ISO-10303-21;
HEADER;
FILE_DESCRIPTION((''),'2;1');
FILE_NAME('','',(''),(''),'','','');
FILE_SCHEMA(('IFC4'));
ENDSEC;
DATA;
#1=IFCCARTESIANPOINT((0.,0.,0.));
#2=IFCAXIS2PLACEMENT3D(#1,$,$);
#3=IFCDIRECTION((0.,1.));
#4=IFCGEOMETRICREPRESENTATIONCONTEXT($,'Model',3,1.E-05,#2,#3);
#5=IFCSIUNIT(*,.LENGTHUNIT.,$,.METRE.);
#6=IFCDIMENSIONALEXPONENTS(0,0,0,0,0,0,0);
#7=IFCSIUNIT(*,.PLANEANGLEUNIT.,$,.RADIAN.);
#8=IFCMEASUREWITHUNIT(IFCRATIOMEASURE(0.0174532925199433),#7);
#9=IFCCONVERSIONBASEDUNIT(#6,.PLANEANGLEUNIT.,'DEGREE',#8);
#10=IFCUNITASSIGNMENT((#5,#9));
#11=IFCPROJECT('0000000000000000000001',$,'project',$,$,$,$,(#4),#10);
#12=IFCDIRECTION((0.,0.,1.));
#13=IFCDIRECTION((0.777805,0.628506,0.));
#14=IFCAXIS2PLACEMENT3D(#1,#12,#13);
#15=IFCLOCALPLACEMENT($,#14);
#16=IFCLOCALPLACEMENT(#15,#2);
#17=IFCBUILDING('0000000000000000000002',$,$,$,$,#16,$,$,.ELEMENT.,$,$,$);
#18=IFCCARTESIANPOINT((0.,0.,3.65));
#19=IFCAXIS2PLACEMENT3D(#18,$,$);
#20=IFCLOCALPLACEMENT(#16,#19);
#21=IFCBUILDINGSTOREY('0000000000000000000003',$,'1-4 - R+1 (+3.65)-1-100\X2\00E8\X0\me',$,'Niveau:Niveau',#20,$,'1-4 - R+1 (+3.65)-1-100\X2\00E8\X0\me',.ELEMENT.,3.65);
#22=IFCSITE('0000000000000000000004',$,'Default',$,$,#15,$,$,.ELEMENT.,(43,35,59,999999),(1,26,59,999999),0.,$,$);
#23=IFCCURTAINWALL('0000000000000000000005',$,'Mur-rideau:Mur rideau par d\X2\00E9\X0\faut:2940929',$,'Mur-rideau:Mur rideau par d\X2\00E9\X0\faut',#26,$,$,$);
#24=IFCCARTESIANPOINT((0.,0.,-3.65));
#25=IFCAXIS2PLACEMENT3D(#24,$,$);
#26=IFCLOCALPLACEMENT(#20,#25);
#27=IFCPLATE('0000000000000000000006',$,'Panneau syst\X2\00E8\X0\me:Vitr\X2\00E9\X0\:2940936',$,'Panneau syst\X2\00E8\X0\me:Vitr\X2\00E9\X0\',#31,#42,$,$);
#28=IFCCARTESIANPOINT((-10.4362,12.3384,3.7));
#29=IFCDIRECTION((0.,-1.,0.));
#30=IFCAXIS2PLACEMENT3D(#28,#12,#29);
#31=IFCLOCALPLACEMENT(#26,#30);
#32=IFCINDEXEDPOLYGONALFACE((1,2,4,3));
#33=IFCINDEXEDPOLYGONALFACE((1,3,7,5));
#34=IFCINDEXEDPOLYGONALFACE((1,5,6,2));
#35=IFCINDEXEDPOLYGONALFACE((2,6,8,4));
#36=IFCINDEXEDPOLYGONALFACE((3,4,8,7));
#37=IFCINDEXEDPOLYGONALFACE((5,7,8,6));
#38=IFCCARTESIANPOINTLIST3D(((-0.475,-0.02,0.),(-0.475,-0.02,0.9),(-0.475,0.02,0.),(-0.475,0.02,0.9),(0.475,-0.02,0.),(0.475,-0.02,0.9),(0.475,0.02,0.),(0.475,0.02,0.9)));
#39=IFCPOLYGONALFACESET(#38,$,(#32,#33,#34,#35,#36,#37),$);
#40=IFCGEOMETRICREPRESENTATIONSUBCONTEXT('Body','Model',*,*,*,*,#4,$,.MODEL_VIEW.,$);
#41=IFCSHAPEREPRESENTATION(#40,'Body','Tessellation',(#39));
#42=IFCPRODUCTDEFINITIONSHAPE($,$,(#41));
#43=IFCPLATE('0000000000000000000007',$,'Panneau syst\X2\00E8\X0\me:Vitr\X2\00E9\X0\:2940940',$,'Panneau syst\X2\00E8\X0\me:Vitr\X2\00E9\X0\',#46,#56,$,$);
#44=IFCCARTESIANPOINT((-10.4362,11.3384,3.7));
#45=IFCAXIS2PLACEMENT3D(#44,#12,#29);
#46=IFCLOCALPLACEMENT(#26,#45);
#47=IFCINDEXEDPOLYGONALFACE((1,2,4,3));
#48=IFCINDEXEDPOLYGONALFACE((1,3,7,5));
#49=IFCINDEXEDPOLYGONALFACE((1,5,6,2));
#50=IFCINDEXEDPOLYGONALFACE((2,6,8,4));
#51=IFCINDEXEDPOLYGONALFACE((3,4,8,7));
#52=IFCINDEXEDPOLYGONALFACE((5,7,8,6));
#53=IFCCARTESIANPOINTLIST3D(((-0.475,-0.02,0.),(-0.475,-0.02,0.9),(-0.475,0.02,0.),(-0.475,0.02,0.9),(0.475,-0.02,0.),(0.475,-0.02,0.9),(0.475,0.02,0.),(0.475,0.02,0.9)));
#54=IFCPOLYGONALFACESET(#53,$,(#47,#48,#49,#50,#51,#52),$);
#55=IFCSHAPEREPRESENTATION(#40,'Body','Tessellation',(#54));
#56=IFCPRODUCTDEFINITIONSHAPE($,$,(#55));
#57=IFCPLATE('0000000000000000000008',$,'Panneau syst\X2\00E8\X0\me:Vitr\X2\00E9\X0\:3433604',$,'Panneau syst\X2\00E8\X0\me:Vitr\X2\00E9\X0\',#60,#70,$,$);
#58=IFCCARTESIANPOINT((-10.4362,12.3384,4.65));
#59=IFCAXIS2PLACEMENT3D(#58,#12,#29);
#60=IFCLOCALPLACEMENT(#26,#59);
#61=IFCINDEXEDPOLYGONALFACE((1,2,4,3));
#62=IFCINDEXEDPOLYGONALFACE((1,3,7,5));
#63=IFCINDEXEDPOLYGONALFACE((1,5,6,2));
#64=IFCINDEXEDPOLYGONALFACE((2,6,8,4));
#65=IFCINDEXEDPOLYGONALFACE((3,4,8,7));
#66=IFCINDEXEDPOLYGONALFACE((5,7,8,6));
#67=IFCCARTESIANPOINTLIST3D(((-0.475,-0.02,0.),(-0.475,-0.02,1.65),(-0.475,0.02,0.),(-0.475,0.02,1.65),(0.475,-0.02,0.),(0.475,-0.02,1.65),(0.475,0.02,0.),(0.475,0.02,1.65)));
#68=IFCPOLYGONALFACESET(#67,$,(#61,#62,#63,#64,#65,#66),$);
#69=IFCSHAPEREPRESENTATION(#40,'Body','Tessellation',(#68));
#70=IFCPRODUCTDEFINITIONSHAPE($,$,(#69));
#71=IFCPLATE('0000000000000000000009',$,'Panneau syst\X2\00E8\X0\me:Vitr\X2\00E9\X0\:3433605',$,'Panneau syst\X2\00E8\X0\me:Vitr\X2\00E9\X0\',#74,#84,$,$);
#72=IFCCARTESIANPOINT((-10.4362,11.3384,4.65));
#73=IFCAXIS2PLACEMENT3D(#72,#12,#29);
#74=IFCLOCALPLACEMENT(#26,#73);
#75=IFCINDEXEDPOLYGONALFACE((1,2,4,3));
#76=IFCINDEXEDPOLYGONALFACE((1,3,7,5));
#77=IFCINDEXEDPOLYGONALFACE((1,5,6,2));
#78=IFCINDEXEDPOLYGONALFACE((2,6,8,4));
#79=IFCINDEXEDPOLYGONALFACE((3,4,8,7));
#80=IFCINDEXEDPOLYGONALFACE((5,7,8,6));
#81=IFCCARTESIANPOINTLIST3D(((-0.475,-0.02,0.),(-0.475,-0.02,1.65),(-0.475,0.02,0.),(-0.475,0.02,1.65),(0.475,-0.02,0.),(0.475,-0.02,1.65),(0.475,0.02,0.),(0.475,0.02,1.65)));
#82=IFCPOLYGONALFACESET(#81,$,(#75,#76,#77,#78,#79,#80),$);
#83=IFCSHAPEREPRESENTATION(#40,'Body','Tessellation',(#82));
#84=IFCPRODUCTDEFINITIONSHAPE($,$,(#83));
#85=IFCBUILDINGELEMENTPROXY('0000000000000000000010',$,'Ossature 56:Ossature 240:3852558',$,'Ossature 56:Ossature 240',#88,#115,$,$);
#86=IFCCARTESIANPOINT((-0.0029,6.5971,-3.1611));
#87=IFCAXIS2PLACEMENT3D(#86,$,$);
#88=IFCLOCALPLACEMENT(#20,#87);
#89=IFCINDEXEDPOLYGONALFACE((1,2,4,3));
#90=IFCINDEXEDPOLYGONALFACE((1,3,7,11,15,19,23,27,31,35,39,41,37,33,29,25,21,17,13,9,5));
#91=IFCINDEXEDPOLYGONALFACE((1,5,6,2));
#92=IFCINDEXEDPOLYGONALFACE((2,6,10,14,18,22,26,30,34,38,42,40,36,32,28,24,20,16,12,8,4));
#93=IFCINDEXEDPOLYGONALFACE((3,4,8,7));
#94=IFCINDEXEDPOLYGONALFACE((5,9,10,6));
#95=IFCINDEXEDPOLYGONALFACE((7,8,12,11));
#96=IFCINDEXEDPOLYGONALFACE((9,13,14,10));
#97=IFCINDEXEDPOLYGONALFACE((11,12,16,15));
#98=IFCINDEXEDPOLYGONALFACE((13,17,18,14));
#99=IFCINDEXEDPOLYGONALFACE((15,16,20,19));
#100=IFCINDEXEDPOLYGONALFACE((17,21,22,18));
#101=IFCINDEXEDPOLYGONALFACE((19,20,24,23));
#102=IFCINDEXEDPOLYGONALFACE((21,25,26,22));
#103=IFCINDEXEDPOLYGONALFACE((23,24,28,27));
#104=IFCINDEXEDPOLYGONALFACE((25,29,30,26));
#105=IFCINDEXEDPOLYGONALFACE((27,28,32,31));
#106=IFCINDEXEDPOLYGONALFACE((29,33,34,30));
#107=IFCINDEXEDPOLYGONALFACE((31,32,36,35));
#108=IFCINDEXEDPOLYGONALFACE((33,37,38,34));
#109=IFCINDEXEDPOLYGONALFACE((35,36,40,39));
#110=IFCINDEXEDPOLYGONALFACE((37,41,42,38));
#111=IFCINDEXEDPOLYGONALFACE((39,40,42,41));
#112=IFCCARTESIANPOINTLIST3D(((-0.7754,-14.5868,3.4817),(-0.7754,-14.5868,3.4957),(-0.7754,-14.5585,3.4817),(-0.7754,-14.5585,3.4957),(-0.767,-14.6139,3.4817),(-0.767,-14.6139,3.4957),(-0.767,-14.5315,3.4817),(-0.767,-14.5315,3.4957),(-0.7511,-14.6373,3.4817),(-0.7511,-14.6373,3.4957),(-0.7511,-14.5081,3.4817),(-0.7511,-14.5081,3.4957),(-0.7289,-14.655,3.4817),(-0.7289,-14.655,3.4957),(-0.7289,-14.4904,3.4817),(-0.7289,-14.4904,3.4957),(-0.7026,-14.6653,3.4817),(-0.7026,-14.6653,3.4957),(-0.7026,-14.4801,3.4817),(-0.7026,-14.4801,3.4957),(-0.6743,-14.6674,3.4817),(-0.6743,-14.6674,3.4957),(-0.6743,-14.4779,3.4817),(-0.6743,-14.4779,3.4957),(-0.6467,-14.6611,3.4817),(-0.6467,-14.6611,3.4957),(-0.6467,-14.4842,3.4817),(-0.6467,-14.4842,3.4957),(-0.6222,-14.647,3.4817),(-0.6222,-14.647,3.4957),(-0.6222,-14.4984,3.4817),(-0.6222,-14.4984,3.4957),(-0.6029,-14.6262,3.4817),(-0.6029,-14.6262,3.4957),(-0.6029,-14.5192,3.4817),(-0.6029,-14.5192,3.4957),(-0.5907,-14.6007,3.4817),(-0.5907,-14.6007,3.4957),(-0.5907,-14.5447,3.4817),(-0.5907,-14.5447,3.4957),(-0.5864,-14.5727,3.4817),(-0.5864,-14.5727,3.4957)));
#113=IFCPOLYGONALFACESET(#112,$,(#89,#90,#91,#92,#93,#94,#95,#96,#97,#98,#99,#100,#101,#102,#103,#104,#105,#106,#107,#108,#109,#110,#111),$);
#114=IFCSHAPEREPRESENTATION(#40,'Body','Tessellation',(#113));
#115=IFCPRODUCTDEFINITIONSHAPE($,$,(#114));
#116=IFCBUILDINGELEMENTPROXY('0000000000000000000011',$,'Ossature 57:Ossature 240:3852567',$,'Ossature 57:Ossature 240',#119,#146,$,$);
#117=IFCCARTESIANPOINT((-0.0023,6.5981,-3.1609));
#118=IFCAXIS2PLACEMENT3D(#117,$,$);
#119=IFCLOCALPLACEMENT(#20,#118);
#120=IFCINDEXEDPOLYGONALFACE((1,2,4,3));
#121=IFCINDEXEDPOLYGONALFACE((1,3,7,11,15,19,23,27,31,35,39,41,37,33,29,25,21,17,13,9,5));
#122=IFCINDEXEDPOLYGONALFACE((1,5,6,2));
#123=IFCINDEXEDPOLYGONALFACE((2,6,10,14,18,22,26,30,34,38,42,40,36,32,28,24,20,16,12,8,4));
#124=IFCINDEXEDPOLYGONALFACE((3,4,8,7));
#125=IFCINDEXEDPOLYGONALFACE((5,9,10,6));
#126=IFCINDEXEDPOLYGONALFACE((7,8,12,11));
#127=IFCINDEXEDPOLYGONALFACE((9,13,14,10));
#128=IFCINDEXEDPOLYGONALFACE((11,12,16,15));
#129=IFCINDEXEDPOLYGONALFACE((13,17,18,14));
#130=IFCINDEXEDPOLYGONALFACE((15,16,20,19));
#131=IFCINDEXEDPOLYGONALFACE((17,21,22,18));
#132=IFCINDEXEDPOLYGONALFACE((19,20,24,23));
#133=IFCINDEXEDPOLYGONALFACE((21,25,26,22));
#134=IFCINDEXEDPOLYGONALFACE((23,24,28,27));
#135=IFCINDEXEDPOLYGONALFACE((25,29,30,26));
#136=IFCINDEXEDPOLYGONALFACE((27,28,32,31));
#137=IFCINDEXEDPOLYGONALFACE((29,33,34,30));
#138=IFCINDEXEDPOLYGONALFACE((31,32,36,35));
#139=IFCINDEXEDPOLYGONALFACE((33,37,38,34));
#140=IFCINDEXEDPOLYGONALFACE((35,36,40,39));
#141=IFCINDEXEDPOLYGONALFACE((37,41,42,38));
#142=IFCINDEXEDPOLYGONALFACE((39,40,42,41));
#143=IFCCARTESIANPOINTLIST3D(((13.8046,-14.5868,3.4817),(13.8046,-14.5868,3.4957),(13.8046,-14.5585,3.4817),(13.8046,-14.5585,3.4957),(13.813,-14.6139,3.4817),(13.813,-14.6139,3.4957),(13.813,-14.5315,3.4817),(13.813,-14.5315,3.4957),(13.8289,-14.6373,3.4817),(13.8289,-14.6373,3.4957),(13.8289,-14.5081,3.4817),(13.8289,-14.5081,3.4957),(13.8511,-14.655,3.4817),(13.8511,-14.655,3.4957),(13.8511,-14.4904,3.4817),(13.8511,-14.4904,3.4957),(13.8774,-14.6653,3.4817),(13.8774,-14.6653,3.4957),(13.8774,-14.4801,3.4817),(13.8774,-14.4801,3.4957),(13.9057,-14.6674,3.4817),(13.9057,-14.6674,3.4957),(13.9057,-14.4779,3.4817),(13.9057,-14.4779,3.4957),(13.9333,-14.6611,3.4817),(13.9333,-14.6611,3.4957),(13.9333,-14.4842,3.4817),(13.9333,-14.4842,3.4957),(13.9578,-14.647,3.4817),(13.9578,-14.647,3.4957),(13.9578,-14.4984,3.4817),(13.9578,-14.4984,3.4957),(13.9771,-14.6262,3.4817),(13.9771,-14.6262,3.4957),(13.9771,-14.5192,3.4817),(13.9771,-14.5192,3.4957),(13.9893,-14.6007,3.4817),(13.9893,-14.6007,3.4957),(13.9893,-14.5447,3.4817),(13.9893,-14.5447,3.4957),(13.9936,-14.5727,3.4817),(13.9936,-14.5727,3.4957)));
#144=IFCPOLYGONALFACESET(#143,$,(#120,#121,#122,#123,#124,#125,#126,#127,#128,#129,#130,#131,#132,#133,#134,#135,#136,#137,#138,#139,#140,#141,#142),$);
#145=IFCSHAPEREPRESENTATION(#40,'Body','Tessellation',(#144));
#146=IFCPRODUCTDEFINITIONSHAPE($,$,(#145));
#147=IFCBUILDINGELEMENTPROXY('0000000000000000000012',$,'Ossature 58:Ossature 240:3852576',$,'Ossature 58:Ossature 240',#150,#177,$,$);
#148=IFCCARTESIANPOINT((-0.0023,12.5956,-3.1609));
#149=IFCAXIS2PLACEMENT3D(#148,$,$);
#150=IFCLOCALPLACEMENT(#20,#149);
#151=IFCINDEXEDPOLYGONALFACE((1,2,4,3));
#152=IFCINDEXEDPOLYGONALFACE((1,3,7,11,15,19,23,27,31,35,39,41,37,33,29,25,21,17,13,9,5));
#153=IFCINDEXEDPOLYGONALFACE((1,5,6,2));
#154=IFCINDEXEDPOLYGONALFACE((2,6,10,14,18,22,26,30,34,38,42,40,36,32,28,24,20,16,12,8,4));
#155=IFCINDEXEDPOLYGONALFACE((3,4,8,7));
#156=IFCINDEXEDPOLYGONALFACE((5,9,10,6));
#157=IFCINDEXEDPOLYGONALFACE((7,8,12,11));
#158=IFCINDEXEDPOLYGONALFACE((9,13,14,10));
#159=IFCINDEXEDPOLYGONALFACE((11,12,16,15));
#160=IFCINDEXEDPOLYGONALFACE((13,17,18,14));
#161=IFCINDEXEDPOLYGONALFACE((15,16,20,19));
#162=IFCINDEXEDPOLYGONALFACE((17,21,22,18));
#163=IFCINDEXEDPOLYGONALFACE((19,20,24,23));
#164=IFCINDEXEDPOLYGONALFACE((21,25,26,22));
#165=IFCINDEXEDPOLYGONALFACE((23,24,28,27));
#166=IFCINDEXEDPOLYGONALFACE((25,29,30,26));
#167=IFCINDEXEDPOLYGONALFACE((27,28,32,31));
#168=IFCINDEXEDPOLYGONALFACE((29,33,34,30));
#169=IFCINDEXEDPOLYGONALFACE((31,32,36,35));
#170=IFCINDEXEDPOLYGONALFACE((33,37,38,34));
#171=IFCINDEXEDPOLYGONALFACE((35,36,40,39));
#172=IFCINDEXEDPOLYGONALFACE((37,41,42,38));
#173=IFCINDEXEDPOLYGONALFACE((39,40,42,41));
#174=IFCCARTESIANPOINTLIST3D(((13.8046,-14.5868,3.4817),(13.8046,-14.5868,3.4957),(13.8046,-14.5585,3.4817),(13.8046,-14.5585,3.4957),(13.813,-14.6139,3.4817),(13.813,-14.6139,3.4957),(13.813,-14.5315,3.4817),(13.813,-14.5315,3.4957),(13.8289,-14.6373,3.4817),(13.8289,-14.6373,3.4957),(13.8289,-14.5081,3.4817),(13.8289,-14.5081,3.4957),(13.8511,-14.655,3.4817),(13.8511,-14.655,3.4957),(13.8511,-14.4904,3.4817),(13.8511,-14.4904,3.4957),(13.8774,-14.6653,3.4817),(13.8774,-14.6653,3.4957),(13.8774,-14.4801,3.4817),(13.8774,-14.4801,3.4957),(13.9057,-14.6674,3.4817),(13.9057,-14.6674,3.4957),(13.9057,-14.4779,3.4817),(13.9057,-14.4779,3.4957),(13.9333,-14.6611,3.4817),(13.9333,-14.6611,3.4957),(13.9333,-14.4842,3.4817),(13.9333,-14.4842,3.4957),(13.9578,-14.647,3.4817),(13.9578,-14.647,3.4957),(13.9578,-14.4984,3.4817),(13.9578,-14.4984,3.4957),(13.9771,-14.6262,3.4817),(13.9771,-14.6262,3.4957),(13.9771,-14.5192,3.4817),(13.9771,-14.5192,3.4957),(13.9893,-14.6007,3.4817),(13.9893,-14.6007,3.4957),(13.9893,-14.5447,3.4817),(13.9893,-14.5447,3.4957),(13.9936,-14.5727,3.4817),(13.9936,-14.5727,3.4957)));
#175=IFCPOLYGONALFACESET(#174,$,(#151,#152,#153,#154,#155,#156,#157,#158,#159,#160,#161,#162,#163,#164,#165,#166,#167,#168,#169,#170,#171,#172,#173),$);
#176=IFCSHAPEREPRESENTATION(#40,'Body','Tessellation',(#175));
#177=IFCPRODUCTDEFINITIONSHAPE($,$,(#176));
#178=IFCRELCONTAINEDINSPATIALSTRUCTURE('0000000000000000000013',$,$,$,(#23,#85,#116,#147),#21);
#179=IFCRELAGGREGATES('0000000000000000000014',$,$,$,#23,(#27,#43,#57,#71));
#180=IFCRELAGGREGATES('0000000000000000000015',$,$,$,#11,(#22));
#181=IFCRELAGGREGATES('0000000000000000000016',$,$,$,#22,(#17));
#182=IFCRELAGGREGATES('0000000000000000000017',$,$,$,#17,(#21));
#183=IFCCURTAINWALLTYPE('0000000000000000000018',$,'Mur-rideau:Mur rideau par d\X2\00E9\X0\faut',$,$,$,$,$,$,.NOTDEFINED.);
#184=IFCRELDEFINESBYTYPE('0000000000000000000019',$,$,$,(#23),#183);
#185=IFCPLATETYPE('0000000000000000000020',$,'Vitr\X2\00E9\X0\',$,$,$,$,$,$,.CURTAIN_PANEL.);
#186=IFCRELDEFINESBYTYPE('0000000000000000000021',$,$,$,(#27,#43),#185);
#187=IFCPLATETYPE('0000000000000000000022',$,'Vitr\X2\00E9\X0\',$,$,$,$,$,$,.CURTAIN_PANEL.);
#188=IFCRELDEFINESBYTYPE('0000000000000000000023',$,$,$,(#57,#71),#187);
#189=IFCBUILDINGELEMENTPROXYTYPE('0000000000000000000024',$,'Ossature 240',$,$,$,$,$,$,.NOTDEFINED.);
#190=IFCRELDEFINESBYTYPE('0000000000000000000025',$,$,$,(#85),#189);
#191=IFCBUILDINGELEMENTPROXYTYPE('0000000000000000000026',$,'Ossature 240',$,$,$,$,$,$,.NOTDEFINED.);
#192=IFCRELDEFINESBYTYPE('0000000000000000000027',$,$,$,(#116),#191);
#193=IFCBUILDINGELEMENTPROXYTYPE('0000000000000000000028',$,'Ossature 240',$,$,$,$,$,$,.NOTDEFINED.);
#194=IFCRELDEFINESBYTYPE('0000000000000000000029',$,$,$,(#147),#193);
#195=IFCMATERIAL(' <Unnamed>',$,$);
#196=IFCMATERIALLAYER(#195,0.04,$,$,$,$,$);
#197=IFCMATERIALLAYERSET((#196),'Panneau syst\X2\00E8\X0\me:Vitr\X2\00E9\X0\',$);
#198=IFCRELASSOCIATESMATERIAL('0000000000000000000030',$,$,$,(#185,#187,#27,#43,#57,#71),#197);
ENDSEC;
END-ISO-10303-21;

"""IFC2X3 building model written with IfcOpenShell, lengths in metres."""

from ifc_helpers import new_model, entity, si_unit, converted_unit, direction, frame, frame_2d, origin, origin_2d_with_axis, place, context, subcontext, project, spatial, rectangle, circle, extrude, source, transform, mapped, material, layer, layer_set, layer_usage, type_object, type_shapes, element, aggregate, save


model = new_model("IFC2X3")

# Units and contexts
model_context = context("Model", 3, precision=1e-05, world=origin(), true_north=direction((0.0, 1.0)))
body_context = subcontext(model_context, "Body", "Model", "MODEL_VIEW")
ifc_project = project(units=[si_unit("LENGTHUNIT", "METRE"), converted_unit("PLANEANGLEUNIT", "DEGREE", entity("IfcRatioMeasure", 0.0174532925199433), si_unit("PLANEANGLEUNIT", "RADIAN"), dimensions=[0, 0, 0, 0, 0, 0, 0])], contexts=[model_context])

# Site, building, storey
site_placement = place(None, frame((0.0, 0.0, 0.0), z_axis=(0.0, 0.0, 1.0), x_axis=(0.777805, 0.628506, 0.0)))
site = spatial("IfcSite", under=ifc_project, at=site_placement, Name="Default", CompositionType="ELEMENT", RefLatitude=(43, 35, 59, 999999), RefLongitude=(1, 26, 59, 999999), RefElevation=0.0)
building_placement = place(site_placement, origin())
building = spatial("IfcBuilding", under=site, at=building_placement, CompositionType="ELEMENT")
storey_placement = place(building_placement, frame((0.0, 0.0, 3.65)))
storey = spatial("IfcBuildingStorey", under=building, at=storey_placement, Name="1-4 - R+1 (+3.65)-1-100ème", ObjectType="Niveau:Niveau", LongName="1-4 - R+1 (+3.65)-1-100ème", CompositionType="ELEMENT", Elevation=3.65)

# Curtain wall, plates
curtain_wall_type = type_object("IfcCurtainWallType", Name="Mur-rideau:Mur rideau par défaut", PredefinedType="NOTDEFINED")
curtain_wall_placement = place(storey_placement, frame((0.0, 0.0, -3.65)))
curtain_wall = element("IfcCurtainWall", 1, at=curtain_wall_placement, inside=storey, type_object=curtain_wall_type, Name="Mur-rideau:Mur rideau par défaut:2940929", ObjectType="Mur-rideau:Mur rideau par défaut")
ifc_material_1 = material(Name=" <Unnamed>")
ifc_layer = layer(ifc_material_1, 0.04)
ifc_layer_set = layer_set([ifc_layer], Name="Panneau système:Vitré")
ifc_layer_usage_1 = layer_usage(ifc_layer_set, "AXIS3", "POSITIVE", 0.0)
plate_type_1 = type_object("IfcPlateType", Name="Vitré", PredefinedType="CURTAIN_PANEL", material=ifc_layer_set)
shared_shape_1 = source(origin(), body_context, "Body", "SweptSolid", [
    extrude(rectangle(XDim=0.04, YDim=0.95, at=frame_2d((0.0, 0.0), x_axis=(1.0, 0.0))), frame((0.0, 0.0, 0.0), z_axis=(0.0, 0.0, 1.0), x_axis=(0.0, 1.0, 0.0)), (0.0, 0.0, 1.0), 0.9),
])
type_shapes(plate_type_1, [shared_shape_1])
plate_1_placement = place(curtain_wall_placement, frame((-10.4362, 12.3384, 3.7), z_axis=(0.0, 0.0, 1.0), x_axis=(0.0, -1.0, 0.0)))
plate_1 = element("IfcPlate", 2, at=plate_1_placement, type_object=plate_type_1, material=ifc_layer_usage_1, Name="Panneau système:Vitré:2940936", ObjectType="Panneau système:Vitré", context=body_context, shape_type="MappedRepresentation", body=[
    mapped(shared_shape_1, transform((0.0, 0.0, 0.0), scale=1.0)),
])
ifc_layer_usage_2 = layer_usage(ifc_layer_set, "AXIS3", "POSITIVE", 0.0)
plate_2_placement = place(curtain_wall_placement, frame((-10.4362, 11.3384, 3.7), z_axis=(0.0, 0.0, 1.0), x_axis=(0.0, -1.0, 0.0)))
plate_2 = element("IfcPlate", 3, at=plate_2_placement, type_object=plate_type_1, material=ifc_layer_usage_2, Name="Panneau système:Vitré:2940940", ObjectType="Panneau système:Vitré", context=body_context, shape_type="MappedRepresentation", body=[
    mapped(shared_shape_1, transform((0.0, 0.0, 0.0), scale=1.0)),
])
ifc_layer_usage_3 = layer_usage(ifc_layer_set, "AXIS3", "POSITIVE", 0.0)
plate_type_2 = type_object("IfcPlateType", Name="Vitré", PredefinedType="CURTAIN_PANEL", material=ifc_layer_set)
shared_shape_2 = source(origin(), body_context, "Body", "SweptSolid", [
    extrude(rectangle(XDim=0.04, YDim=0.95, at=origin_2d_with_axis()), frame((0.0, 0.0, 0.0), z_axis=(0.0, 0.0, 1.0), x_axis=(0.0, 1.0, 0.0)), (0.0, 0.0, 1.0), 1.65),
])
type_shapes(plate_type_2, [shared_shape_2])
plate_3_placement = place(curtain_wall_placement, frame((-10.4362, 12.3384, 4.65), z_axis=(0.0, 0.0, 1.0), x_axis=(0.0, -1.0, 0.0)))
plate_3 = element("IfcPlate", 4, at=plate_3_placement, type_object=plate_type_2, material=ifc_layer_usage_3, Name="Panneau système:Vitré:3433604", ObjectType="Panneau système:Vitré", context=body_context, shape_type="MappedRepresentation", body=[
    mapped(shared_shape_2, transform((0.0, 0.0, 0.0), scale=1.0)),
])
ifc_layer_usage_4 = layer_usage(ifc_layer_set, "AXIS3", "POSITIVE", 0.0)
plate_4_placement = place(curtain_wall_placement, frame((-10.4362, 11.3384, 4.65), z_axis=(0.0, 0.0, 1.0), x_axis=(0.0, -1.0, 0.0)))
plate_4 = element("IfcPlate", 5, at=plate_4_placement, type_object=plate_type_2, material=ifc_layer_usage_4, Name="Panneau système:Vitré:3433605", ObjectType="Panneau système:Vitré", context=body_context, shape_type="MappedRepresentation", body=[
    mapped(shared_shape_2, transform((0.0, 0.0, 0.0), scale=1.0)),
])
aggregate(curtain_wall, [plate_1, plate_2, plate_3, plate_4])

# Building element proxies
building_element_proxy_type_1 = type_object("IfcBuildingElementProxyType", Name="Ossature 240", PredefinedType="NOTDEFINED")
shared_shape_3 = source(origin(), body_context, "Body", "SweptSolid", [
    extrude(circle(Radius=0.095, at=origin_2d_with_axis()), frame((-0.6814, -14.5727, 3.4817)), (0.0, 0.0, 1.0), 0.014),
])
type_shapes(building_element_proxy_type_1, [shared_shape_3])
proxy_1_placement = place(storey_placement, frame((-0.0029, 6.5971, -3.1611)))
element("IfcBuildingElementProxy", 6, at=proxy_1_placement, inside=storey, type_object=building_element_proxy_type_1, Name="Ossature 56:Ossature 240:3852558", ObjectType="Ossature 56:Ossature 240", context=body_context, shape_type="MappedRepresentation", body=[
    mapped(shared_shape_3, transform((0.0, 0.0, 0.0), scale=1.0)),
])
building_element_proxy_type_2 = type_object("IfcBuildingElementProxyType", Name="Ossature 240", PredefinedType="NOTDEFINED")
shared_shape_4 = source(origin(), body_context, "Body", "SweptSolid", [
    extrude(circle(Radius=0.095, at=origin_2d_with_axis()), frame((13.8986, -14.5727, 3.4817)), (0.0, 0.0, 1.0), 0.014),
])
type_shapes(building_element_proxy_type_2, [shared_shape_4])
proxy_2_placement = place(storey_placement, frame((-0.0023, 6.5981, -3.1609)))
element("IfcBuildingElementProxy", 7, at=proxy_2_placement, inside=storey, type_object=building_element_proxy_type_2, Name="Ossature 57:Ossature 240:3852567", ObjectType="Ossature 57:Ossature 240", context=body_context, shape_type="MappedRepresentation", body=[
    mapped(shared_shape_4, transform((0.0, 0.0, 0.0), scale=1.0)),
])
building_element_proxy_type_3 = type_object("IfcBuildingElementProxyType", Name="Ossature 240", PredefinedType="NOTDEFINED")
shared_shape_5 = source(origin(), body_context, "Body", "SweptSolid", [
    extrude(circle(Radius=0.095, at=origin_2d_with_axis()), frame((13.8986, -14.5727, 3.4817)), (0.0, 0.0, 1.0), 0.014),
])
type_shapes(building_element_proxy_type_3, [shared_shape_5])
proxy_3_placement = place(storey_placement, frame((-0.0023, 12.5956, -3.1609)))
element("IfcBuildingElementProxy", 8, at=proxy_3_placement, inside=storey, type_object=building_element_proxy_type_3, Name="Ossature 58:Ossature 240:3852576", ObjectType="Ossature 58:Ossature 240", context=body_context, shape_type="MappedRepresentation", body=[
    mapped(shared_shape_5, transform((0.0, 0.0, 0.0), scale=1.0)),
])

save(model, "model.ifc")
